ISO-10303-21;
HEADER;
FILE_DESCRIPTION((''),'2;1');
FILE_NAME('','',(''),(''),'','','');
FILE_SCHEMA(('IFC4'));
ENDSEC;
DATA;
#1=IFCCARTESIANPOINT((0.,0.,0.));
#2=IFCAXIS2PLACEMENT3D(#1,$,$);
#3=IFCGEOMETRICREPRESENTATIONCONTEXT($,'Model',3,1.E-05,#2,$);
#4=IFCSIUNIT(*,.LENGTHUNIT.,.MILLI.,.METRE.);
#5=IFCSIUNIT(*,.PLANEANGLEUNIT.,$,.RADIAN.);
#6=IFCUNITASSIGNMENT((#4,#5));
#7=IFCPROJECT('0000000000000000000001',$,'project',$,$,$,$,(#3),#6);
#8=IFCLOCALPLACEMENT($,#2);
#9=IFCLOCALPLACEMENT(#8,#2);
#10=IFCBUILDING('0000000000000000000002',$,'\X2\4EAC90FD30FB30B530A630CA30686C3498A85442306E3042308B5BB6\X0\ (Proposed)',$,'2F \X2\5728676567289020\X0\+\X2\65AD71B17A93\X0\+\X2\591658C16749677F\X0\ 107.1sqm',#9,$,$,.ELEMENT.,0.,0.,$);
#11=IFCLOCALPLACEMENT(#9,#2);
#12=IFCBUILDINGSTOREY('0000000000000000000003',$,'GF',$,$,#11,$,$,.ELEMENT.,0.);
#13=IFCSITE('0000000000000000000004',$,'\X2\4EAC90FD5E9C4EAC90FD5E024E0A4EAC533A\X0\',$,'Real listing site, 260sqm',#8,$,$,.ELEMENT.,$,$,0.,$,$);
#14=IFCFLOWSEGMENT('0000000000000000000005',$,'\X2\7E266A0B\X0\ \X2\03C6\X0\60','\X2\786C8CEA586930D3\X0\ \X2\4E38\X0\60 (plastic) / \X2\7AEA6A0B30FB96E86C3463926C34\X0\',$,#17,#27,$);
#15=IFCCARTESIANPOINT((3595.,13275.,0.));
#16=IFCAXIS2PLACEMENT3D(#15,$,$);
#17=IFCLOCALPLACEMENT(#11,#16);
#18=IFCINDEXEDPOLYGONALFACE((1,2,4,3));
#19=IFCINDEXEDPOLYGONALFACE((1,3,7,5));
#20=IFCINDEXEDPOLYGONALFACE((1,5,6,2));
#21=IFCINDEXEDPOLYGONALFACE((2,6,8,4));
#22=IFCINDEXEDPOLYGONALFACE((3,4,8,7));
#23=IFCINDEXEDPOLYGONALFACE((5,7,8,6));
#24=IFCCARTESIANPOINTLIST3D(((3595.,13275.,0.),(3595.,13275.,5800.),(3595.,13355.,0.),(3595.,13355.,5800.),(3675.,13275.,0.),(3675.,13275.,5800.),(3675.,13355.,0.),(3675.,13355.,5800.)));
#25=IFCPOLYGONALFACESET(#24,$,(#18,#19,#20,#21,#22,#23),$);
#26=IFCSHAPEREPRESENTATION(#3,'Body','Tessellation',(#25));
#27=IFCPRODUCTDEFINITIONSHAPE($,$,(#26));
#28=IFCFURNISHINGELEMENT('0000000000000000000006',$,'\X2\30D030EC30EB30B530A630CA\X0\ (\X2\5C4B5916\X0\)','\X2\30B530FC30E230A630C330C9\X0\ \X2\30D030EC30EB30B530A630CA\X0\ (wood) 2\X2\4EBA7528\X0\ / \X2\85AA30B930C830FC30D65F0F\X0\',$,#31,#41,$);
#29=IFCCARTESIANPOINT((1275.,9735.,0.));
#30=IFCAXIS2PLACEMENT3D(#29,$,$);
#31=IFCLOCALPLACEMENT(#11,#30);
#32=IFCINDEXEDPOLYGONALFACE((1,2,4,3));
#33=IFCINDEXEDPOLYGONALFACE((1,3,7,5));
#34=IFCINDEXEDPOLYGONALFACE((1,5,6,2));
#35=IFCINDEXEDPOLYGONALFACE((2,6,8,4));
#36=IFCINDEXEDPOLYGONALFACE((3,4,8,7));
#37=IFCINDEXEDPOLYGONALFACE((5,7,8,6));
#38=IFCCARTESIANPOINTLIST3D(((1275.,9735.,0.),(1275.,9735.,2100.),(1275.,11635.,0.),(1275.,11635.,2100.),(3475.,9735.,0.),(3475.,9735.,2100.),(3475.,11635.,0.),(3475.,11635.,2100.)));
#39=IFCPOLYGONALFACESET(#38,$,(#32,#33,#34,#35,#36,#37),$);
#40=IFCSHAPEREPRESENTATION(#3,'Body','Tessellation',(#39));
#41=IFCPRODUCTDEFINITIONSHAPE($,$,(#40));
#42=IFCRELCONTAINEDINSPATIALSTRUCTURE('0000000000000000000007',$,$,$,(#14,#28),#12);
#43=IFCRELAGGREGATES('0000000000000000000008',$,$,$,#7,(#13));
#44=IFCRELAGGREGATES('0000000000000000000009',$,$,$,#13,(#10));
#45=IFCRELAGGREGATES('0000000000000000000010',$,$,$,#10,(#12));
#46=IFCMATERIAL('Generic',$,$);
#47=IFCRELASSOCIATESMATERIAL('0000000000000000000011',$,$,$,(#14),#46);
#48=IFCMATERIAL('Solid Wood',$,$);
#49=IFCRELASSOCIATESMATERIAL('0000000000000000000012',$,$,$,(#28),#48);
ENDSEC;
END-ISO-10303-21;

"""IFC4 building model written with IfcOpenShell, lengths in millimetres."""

from ifc_helpers import new_model, si_unit, frame, frame_2d, origin, place, context, project, spatial, rectangle, extrude, material, element, save


model = new_model("IFC4")

# Units and contexts
model_context = context("Model", 3, precision=1e-05, world=origin())
ifc_project = project(units=[si_unit("LENGTHUNIT", "METRE", prefix="MILLI"), si_unit("PLANEANGLEUNIT", "RADIAN")], contexts=[model_context])

# Site, building, storey
site_placement = place(None, origin())
site = spatial("IfcSite", under=ifc_project, at=site_placement, Name="京都府京都市上京区", ObjectType="Real listing site, 260sqm", CompositionType="ELEMENT", RefElevation=0.0)
building_placement = place(site_placement, origin())
building = spatial("IfcBuilding", under=site, at=building_placement, Name="京都・サウナと水風呂のある家 (Proposed)", ObjectType="2F 在来木造+断熱窓+外壁杉板 107.1sqm", CompositionType="ELEMENT", ElevationOfRefHeight=0.0, ElevationOfTerrain=0.0)
storey_placement = place(building_placement, origin())
storey = spatial("IfcBuildingStorey", under=building, at=storey_placement, Name="GF", CompositionType="ELEMENT", Elevation=0.0)

# Shared definitions
ifc_material_1 = material(Name="Solid Wood")

# Shared definitions
ifc_material_2 = material(Name="Generic")

# Flow segment
flow_segment_placement = place(storey_placement, frame((3595.0, 13275.0, 0.0)))
element("IfcFlowSegment", 1, at=flow_segment_placement, inside=storey, material=ifc_material_2, Name="縦樋 φ60", Description="硬質塩ビ 丸60 (plastic) / 竪樋・雨水排水", context=model_context, shape_type="SweptSolid", body=[
    extrude(rectangle(XDim=80.0, YDim=80.0, at=frame_2d((40.0, 40.0))), frame((3595.0, 13275.0, 0.0)), (0.0, 0.0, 1.0), 5800.0),
])

# Furnishing element
furnishing_placement = place(storey_placement, frame((1275.0, 9735.0, 0.0)))
element("IfcFurnishingElement", 2, at=furnishing_placement, inside=storey, material=ifc_material_1, Name="バレルサウナ (屋外)", Description="サーモウッド バレルサウナ (wood) 2人用 / 薪ストーブ式", context=model_context, shape_type="SweptSolid", body=[
    extrude(rectangle(XDim=2200.0, YDim=1900.0, at=frame_2d((1100.0, 950.0))), frame((1275.0, 9735.0, 0.0)), (0.0, 0.0, 1.0), 2100.0),
])

save(model, "model.ifc")
